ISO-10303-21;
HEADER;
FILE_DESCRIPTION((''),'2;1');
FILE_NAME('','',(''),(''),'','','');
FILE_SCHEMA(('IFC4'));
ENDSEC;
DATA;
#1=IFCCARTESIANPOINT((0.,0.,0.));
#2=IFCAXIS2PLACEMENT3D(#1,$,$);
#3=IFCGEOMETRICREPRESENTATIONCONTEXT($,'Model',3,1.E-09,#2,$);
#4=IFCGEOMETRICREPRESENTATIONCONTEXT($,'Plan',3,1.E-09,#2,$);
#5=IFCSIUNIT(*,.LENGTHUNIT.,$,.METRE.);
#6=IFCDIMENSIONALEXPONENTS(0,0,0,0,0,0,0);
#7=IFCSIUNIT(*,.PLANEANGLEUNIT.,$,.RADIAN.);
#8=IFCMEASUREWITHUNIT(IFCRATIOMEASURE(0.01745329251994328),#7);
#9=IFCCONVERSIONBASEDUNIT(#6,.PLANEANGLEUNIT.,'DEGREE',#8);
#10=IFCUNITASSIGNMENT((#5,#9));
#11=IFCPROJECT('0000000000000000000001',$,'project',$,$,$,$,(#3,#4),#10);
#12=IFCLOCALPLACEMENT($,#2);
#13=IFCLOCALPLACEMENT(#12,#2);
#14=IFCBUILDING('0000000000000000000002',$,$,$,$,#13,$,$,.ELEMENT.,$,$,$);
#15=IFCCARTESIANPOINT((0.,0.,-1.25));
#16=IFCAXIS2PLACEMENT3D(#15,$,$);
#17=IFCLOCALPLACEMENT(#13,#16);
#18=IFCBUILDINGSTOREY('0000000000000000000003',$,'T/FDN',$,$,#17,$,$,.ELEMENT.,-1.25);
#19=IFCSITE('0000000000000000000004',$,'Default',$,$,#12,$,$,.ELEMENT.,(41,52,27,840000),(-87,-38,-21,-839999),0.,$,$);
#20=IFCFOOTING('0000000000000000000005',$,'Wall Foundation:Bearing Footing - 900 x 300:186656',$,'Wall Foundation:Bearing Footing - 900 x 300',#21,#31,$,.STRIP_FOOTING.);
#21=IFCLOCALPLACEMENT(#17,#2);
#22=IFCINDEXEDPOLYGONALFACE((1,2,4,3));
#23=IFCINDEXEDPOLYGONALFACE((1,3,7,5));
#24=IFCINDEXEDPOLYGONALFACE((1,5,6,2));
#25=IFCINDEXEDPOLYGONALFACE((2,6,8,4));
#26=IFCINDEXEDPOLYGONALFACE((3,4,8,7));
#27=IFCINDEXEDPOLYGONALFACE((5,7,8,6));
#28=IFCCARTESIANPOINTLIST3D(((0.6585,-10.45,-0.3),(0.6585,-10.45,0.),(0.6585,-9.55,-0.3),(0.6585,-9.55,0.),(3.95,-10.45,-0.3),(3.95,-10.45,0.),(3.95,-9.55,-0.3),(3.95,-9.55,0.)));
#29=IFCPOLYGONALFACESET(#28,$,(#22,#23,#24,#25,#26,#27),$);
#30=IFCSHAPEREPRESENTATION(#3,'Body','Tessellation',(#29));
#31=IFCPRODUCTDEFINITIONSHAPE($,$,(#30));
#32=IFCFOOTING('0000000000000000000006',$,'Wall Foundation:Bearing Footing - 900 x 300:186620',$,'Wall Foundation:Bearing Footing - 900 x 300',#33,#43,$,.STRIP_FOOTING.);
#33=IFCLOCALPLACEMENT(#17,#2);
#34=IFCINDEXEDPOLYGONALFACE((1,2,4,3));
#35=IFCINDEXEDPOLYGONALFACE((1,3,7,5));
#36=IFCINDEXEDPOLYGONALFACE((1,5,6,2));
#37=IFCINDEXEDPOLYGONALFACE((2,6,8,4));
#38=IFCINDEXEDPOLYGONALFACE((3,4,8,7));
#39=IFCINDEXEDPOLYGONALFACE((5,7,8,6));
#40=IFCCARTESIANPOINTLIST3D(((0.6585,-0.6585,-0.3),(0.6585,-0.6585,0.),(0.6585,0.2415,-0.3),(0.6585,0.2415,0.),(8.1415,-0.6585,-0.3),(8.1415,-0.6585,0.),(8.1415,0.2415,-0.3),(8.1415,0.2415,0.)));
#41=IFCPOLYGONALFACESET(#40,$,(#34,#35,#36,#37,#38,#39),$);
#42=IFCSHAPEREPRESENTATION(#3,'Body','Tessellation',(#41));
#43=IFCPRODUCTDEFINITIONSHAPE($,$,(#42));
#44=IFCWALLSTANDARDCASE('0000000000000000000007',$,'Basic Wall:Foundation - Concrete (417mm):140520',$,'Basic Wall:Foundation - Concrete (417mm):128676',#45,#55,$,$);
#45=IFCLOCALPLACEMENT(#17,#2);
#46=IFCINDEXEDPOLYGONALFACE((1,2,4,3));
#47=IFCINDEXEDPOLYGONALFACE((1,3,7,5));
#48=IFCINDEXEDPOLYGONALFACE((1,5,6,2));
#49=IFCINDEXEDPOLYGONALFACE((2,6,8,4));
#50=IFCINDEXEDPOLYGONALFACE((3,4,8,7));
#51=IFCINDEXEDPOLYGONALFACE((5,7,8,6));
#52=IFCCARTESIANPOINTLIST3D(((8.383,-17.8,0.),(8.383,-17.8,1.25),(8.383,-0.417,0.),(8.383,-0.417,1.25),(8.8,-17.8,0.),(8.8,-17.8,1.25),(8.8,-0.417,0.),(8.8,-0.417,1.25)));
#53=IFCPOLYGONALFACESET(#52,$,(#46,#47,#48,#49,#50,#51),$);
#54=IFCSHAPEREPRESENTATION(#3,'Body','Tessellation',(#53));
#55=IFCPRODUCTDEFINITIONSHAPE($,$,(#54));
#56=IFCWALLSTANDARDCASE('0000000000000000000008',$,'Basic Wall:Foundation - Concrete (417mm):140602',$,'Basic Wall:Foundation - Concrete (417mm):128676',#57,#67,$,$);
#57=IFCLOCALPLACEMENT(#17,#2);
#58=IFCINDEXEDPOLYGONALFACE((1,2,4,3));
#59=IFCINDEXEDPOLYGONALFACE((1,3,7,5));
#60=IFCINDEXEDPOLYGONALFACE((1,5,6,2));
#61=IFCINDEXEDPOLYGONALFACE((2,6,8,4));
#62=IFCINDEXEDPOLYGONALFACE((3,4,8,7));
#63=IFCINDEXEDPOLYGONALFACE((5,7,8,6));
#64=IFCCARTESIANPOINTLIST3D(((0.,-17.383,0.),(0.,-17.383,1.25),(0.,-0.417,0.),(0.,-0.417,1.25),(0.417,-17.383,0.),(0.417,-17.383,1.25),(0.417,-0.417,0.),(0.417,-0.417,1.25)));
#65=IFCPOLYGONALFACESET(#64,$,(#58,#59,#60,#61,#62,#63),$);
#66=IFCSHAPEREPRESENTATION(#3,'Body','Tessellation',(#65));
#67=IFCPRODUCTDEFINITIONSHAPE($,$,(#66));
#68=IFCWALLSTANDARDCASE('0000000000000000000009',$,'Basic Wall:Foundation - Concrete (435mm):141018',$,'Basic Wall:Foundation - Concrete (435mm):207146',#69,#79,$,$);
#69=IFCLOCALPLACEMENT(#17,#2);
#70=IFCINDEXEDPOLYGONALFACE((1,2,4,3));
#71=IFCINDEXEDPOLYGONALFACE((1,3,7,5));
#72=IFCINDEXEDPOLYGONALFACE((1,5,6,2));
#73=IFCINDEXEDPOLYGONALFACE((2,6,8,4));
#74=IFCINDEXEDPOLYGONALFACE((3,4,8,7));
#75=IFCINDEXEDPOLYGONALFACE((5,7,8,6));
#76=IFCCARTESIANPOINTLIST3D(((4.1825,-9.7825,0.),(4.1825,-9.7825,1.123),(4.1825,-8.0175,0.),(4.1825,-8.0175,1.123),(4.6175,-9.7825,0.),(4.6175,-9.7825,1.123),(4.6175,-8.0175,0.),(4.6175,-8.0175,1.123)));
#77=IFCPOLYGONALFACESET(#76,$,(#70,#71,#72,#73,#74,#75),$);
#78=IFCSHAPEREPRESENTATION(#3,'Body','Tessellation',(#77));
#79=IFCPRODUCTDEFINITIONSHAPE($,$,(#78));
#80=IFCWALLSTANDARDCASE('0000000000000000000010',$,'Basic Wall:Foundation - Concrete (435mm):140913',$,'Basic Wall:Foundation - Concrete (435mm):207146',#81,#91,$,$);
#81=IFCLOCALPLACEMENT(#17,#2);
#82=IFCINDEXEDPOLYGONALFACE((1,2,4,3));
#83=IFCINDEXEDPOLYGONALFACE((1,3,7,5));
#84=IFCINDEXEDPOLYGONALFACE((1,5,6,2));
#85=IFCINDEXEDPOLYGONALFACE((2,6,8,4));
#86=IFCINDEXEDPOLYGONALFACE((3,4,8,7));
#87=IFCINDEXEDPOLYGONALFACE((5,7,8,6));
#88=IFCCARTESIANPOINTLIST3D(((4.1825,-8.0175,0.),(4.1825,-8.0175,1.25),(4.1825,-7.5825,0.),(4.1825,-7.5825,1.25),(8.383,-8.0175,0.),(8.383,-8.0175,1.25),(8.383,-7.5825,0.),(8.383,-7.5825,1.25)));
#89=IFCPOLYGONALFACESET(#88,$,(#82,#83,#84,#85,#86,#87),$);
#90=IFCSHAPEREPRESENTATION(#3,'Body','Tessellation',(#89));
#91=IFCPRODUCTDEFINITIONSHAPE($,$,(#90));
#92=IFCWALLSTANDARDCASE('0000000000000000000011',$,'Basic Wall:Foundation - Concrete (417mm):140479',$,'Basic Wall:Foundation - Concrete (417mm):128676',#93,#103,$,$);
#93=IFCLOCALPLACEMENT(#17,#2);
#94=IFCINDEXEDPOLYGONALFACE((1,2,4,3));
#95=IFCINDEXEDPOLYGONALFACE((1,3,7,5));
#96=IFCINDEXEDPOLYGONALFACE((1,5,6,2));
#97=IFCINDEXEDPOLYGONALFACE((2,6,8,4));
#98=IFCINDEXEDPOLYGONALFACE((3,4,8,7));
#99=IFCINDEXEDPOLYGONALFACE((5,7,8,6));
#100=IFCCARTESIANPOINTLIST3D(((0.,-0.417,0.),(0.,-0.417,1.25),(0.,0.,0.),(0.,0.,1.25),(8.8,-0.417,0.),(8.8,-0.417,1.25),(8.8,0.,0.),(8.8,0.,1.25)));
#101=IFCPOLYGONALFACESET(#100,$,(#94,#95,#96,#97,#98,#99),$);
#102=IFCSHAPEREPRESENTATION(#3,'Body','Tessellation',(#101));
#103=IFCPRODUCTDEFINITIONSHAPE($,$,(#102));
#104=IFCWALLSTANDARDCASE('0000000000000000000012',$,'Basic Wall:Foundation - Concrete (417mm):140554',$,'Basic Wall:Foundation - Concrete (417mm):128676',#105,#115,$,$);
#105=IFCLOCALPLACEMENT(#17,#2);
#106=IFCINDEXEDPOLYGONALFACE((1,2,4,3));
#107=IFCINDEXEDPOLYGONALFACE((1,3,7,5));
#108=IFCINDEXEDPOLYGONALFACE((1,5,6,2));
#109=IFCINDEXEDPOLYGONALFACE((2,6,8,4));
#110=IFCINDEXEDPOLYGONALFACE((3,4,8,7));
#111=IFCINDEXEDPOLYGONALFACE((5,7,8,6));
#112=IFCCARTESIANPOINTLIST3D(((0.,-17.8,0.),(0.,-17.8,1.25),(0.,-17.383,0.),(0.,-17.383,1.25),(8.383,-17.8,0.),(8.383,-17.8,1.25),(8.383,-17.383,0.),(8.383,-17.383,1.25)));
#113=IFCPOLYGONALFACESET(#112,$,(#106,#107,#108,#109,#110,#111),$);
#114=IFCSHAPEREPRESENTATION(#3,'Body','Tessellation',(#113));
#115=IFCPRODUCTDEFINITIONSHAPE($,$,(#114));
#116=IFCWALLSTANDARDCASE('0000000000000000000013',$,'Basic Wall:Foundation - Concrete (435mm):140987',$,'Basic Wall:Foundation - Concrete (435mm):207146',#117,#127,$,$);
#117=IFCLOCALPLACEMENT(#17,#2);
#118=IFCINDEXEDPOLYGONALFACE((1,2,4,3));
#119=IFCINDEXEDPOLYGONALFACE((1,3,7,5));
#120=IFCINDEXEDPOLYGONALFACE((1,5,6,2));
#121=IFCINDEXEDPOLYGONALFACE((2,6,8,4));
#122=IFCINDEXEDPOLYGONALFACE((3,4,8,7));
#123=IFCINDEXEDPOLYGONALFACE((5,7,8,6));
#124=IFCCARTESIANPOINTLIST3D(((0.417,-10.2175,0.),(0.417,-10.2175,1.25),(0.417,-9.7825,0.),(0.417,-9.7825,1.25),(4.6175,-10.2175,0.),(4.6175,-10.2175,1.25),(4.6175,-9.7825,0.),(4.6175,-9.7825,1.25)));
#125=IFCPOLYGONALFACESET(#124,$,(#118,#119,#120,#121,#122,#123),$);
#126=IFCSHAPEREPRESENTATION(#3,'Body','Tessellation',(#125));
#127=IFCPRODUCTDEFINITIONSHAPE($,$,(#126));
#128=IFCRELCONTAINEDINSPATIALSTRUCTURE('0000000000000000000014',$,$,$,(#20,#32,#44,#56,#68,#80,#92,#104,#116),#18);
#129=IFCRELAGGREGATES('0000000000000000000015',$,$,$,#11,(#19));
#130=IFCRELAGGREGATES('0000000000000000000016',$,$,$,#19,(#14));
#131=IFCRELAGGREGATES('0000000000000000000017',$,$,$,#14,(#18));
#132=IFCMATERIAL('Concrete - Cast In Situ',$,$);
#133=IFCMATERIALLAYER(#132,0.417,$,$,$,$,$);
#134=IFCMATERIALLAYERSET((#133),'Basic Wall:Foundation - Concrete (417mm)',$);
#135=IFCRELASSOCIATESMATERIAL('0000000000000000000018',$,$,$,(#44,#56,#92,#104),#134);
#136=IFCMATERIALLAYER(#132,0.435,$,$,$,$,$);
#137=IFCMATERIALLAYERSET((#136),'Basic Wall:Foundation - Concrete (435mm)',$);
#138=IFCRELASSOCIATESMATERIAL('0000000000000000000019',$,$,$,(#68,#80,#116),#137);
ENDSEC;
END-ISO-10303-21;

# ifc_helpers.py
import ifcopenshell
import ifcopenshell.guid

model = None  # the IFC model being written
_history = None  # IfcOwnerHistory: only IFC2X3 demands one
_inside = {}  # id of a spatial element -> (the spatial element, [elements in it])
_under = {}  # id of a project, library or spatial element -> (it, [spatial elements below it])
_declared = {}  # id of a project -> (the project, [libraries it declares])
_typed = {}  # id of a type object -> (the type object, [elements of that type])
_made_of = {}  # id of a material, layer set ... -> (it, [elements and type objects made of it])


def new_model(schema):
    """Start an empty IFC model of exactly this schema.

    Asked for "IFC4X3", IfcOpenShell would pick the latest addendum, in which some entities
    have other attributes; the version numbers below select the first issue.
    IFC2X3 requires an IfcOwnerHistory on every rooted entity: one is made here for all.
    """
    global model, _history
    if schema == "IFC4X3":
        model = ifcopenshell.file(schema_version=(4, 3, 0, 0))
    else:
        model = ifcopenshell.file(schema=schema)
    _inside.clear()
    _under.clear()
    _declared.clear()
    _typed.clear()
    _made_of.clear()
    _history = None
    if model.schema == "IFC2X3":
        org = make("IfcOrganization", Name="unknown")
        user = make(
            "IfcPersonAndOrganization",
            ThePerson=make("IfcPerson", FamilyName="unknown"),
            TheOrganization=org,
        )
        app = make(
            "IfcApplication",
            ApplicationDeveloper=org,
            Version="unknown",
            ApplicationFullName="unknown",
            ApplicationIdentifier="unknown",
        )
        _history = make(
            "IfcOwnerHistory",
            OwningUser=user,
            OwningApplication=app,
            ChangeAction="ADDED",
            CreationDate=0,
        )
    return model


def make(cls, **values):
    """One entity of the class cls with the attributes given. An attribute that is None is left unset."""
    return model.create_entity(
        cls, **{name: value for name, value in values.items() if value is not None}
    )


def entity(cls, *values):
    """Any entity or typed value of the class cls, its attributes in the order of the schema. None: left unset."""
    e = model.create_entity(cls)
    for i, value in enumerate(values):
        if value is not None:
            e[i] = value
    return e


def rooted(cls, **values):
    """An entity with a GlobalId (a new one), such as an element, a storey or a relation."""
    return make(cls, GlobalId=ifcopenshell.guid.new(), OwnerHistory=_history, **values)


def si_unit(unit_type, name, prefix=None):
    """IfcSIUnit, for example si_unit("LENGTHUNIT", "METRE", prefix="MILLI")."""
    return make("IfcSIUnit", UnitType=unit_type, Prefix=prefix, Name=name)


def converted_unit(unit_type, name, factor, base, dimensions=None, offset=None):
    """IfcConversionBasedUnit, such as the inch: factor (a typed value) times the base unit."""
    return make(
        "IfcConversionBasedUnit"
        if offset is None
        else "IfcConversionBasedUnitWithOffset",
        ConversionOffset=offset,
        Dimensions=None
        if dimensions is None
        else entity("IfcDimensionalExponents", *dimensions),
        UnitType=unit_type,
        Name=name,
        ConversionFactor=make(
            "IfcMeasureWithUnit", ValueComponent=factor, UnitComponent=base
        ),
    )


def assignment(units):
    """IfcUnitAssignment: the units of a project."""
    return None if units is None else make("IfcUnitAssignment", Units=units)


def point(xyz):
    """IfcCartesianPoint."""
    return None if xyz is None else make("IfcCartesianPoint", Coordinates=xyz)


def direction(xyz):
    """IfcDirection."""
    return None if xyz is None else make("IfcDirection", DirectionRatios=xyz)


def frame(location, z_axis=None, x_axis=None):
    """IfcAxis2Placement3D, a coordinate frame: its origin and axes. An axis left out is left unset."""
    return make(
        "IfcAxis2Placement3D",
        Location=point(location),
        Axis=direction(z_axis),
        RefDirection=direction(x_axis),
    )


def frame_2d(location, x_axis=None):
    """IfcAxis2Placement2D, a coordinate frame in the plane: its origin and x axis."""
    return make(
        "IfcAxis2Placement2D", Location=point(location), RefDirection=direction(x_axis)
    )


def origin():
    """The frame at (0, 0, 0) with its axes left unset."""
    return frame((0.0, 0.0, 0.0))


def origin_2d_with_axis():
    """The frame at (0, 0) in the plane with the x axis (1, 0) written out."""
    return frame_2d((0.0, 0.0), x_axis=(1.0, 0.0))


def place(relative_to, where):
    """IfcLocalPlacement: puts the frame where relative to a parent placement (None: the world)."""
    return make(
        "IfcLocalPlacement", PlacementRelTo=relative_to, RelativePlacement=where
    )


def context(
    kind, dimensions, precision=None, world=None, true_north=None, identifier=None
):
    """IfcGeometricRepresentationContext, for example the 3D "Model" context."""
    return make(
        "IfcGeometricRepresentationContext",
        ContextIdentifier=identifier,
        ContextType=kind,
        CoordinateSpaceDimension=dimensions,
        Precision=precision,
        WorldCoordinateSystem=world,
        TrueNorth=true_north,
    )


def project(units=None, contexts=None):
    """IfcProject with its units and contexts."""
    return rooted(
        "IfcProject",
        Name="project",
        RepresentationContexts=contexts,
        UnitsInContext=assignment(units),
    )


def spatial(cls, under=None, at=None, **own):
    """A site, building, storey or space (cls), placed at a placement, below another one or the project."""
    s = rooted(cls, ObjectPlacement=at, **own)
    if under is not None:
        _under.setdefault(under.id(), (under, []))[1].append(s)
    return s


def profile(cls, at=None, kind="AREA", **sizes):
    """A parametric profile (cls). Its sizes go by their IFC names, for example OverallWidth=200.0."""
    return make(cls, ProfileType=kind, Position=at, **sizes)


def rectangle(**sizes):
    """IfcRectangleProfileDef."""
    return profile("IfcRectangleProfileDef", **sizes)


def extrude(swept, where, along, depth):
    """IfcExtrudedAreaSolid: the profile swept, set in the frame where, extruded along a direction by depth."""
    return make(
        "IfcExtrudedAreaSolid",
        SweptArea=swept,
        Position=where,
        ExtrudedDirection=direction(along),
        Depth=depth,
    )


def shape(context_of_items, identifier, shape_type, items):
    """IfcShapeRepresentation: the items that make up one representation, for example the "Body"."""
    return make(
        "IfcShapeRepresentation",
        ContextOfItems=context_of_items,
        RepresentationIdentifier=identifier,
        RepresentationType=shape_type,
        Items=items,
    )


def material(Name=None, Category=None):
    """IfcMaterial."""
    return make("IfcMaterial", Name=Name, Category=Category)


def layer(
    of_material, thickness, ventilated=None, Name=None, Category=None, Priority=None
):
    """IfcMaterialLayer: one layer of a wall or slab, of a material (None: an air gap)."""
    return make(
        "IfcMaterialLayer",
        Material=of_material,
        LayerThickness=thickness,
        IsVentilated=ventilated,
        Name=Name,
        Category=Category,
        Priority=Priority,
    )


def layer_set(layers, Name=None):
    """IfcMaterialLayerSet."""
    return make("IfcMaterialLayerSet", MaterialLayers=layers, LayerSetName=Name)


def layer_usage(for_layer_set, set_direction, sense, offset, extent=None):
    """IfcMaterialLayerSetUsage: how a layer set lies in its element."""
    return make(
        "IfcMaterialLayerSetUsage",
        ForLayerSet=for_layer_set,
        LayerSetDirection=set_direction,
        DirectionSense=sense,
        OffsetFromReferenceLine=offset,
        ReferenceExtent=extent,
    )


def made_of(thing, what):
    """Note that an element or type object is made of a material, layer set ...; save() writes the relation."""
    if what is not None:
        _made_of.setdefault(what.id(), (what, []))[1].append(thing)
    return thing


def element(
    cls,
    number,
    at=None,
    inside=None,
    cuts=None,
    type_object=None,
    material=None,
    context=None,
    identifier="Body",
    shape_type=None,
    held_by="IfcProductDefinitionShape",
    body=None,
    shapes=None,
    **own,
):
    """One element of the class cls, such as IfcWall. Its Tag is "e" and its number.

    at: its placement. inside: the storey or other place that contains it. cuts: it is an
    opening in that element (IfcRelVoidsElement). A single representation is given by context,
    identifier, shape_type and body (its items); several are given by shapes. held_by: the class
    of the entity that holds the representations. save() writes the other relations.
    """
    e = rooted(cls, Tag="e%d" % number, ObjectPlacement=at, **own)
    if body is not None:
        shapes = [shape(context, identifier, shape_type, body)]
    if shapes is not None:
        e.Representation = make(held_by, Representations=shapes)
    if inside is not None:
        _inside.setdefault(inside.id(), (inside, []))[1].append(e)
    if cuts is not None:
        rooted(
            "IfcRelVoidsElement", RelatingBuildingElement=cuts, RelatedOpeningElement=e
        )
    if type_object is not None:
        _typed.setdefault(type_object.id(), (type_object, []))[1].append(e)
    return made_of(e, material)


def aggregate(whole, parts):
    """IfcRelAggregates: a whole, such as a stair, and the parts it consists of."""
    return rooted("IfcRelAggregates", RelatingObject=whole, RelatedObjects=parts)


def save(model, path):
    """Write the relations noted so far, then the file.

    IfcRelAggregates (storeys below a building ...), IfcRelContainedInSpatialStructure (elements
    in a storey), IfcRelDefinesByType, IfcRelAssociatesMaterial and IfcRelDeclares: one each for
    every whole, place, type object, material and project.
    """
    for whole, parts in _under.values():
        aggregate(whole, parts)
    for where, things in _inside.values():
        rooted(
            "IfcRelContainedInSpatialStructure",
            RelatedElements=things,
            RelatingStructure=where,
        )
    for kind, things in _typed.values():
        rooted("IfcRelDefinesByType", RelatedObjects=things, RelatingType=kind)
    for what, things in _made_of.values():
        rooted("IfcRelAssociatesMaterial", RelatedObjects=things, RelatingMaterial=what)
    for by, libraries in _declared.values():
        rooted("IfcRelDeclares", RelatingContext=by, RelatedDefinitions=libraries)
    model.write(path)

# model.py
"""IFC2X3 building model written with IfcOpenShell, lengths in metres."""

from ifc_helpers import new_model, entity, si_unit, converted_unit, frame, frame_2d, origin, origin_2d_with_axis, place, context, project, spatial, rectangle, extrude, material, layer, layer_set, layer_usage, element, save


model = new_model("IFC2X3")

# Units and contexts
model_context = context("Model", 3, precision=1e-09, world=origin())
plan_context = context("Plan", 3, precision=1e-09, world=origin())
ifc_project = project(units=[si_unit("LENGTHUNIT", "METRE"), converted_unit("PLANEANGLEUNIT", "DEGREE", entity("IfcRatioMeasure", 0.01745329251994328), si_unit("PLANEANGLEUNIT", "RADIAN"), dimensions=[0, 0, 0, 0, 0, 0, 0])], contexts=[model_context, plan_context])

# Site, building, storey
site_placement = place(None, origin())
site = spatial("IfcSite", under=ifc_project, at=site_placement, Name="Default", CompositionType="ELEMENT", RefLatitude=(41, 52, 27, 840000), RefLongitude=(-87, -38, -21, -839999), RefElevation=0.0)
building_placement = place(site_placement, origin())
building = spatial("IfcBuilding", under=site, at=building_placement, CompositionType="ELEMENT")
storey_placement = place(building_placement, frame((0.0, 0.0, -1.25)))
storey = spatial("IfcBuildingStorey", under=building, at=storey_placement, Name="T/FDN", CompositionType="ELEMENT", Elevation=-1.25)

# Footings
footing_1_placement = place(storey_placement, origin())
element("IfcFooting", 1, at=footing_1_placement, inside=storey, Name="Wall Foundation:Bearing Footing - 900 x 300:186656", ObjectType="Wall Foundation:Bearing Footing - 900 x 300", PredefinedType="STRIP_FOOTING", context=model_context, shape_type="SweptSolid", body=[
    extrude(rectangle(XDim=3.2915, YDim=0.9, at=origin_2d_with_axis()), frame((2.3042, -10.0, -0.3)), (0.0, 0.0, 1.0), 0.3),
])
footing_2_placement = place(storey_placement, origin())
element("IfcFooting", 2, at=footing_2_placement, inside=storey, Name="Wall Foundation:Bearing Footing - 900 x 300:186620", ObjectType="Wall Foundation:Bearing Footing - 900 x 300", PredefinedType="STRIP_FOOTING", context=model_context, shape_type="SweptSolid", body=[
    extrude(rectangle(XDim=7.483, YDim=0.9, at=origin_2d_with_axis()), frame((4.4, -0.2085, -0.3), z_axis=(0.0, 0.0, 1.0), x_axis=(-1.0, 0.0, 0.0)), (0.0, 0.0, 1.0), 0.3),
])

# Walls
ifc_material = material(Name="Concrete - Cast In Situ")
ifc_layer_1 = layer(ifc_material, 0.417)
ifc_layer_set_1 = layer_set([ifc_layer_1], Name="Basic Wall:Foundation - Concrete (417mm)")
ifc_layer_usage_1 = layer_usage(ifc_layer_set_1, "AXIS2", "NEGATIVE", 0.2085)
wall_1_placement = place(storey_placement, frame((8.5915, -0.417, 0.0), z_axis=(0.0, 0.0, 1.0), x_axis=(0.0, -1.0, 0.0)))
element("IfcWallStandardCase", 3, at=wall_1_placement, inside=storey, material=ifc_layer_usage_1, Name="Basic Wall:Foundation - Concrete (417mm):140520", ObjectType="Basic Wall:Foundation - Concrete (417mm):128676", context=model_context, shape_type="SweptSolid", body=[
    extrude(rectangle(XDim=17.383, YDim=0.417, at=frame_2d((8.6915, 0.0), x_axis=(-1.0, 0.0))), origin(), (0.0, 0.0, 1.0), 1.25),
])
wall_2_placement = place(storey_placement, frame((0.2085, -17.383, 0.0), z_axis=(0.0, 0.0, 1.0), x_axis=(0.0, 1.0, 0.0)))
element("IfcWallStandardCase", 4, at=wall_2_placement, inside=storey, material=ifc_layer_usage_1, Name="Basic Wall:Foundation - Concrete (417mm):140602", ObjectType="Basic Wall:Foundation - Concrete (417mm):128676", context=model_context, shape_type="SweptSolid", body=[
    extrude(rectangle(XDim=16.966, YDim=0.417, at=frame_2d((8.483, 0.0), x_axis=(-1.0, 0.0))), origin(), (0.0, 0.0, 1.0), 1.25),
])
ifc_layer_2 = layer(ifc_material, 0.435)
ifc_layer_set_2 = layer_set([ifc_layer_2], Name="Basic Wall:Foundation - Concrete (435mm)")
ifc_layer_usage_2 = layer_usage(ifc_layer_set_2, "AXIS2", "NEGATIVE", 0.2175)
wall_3_placement = place(storey_placement, frame((4.4, -9.7825, 0.0), z_axis=(0.0, 0.0, 1.0), x_axis=(0.0, 1.0, 0.0)))
element("IfcWallStandardCase", 5, at=wall_3_placement, inside=storey, material=ifc_layer_usage_2, Name="Basic Wall:Foundation - Concrete (435mm):141018", ObjectType="Basic Wall:Foundation - Concrete (435mm):207146", context=model_context, shape_type="SweptSolid", body=[
    extrude(rectangle(XDim=1.765, YDim=0.435, at=frame_2d((0.8825, 0.0), x_axis=(-1.0, 0.0))), origin(), (0.0, 0.0, 1.0), 1.123),
])
wall_4_placement = place(storey_placement, frame((8.383, -7.8, 0.0), z_axis=(0.0, 0.0, 1.0), x_axis=(-1.0, 0.0, 0.0)))
element("IfcWallStandardCase", 6, at=wall_4_placement, inside=storey, material=ifc_layer_usage_2, Name="Basic Wall:Foundation - Concrete (435mm):140913", ObjectType="Basic Wall:Foundation - Concrete (435mm):207146", context=model_context, shape_type="SweptSolid", body=[
    extrude(rectangle(XDim=4.2005, YDim=0.435, at=frame_2d((2.1002, 0.0), x_axis=(-1.0, 0.0))), origin(), (0.0, 0.0, 1.0), 1.25),
])
wall_5_placement = place(storey_placement, frame((0.0, -0.2085, 0.0)))
element("IfcWallStandardCase", 7, at=wall_5_placement, inside=storey, material=ifc_layer_usage_1, Name="Basic Wall:Foundation - Concrete (417mm):140479", ObjectType="Basic Wall:Foundation - Concrete (417mm):128676", context=model_context, shape_type="SweptSolid", body=[
    extrude(rectangle(XDim=8.8, YDim=0.417, at=frame_2d((4.4, 0.0), x_axis=(-1.0, 0.0))), origin(), (0.0, 0.0, 1.0), 1.25),
])
wall_6_placement = place(storey_placement, frame((8.383, -17.5915, 0.0), z_axis=(0.0, 0.0, 1.0), x_axis=(-1.0, 0.0, 0.0)))
element("IfcWallStandardCase", 8, at=wall_6_placement, inside=storey, material=ifc_layer_usage_1, Name="Basic Wall:Foundation - Concrete (417mm):140554", ObjectType="Basic Wall:Foundation - Concrete (417mm):128676", context=model_context, shape_type="SweptSolid", body=[
    extrude(rectangle(XDim=8.383, YDim=0.417, at=frame_2d((4.1915, 0.0), x_axis=(-1.0, 0.0))), origin(), (0.0, 0.0, 1.0), 1.25),
])
wall_7_placement = place(storey_placement, frame((0.417, -10.0, 0.0)))
element("IfcWallStandardCase", 9, at=wall_7_placement, inside=storey, material=ifc_layer_usage_2, Name="Basic Wall:Foundation - Concrete (435mm):140987", ObjectType="Basic Wall:Foundation - Concrete (435mm):207146", context=model_context, shape_type="SweptSolid", body=[
    extrude(rectangle(XDim=4.2005, YDim=0.435, at=frame_2d((2.1002, 0.0), x_axis=(-1.0, 0.0))), origin(), (0.0, 0.0, 1.0), 1.25),
])

save(model, "model.ifc")
